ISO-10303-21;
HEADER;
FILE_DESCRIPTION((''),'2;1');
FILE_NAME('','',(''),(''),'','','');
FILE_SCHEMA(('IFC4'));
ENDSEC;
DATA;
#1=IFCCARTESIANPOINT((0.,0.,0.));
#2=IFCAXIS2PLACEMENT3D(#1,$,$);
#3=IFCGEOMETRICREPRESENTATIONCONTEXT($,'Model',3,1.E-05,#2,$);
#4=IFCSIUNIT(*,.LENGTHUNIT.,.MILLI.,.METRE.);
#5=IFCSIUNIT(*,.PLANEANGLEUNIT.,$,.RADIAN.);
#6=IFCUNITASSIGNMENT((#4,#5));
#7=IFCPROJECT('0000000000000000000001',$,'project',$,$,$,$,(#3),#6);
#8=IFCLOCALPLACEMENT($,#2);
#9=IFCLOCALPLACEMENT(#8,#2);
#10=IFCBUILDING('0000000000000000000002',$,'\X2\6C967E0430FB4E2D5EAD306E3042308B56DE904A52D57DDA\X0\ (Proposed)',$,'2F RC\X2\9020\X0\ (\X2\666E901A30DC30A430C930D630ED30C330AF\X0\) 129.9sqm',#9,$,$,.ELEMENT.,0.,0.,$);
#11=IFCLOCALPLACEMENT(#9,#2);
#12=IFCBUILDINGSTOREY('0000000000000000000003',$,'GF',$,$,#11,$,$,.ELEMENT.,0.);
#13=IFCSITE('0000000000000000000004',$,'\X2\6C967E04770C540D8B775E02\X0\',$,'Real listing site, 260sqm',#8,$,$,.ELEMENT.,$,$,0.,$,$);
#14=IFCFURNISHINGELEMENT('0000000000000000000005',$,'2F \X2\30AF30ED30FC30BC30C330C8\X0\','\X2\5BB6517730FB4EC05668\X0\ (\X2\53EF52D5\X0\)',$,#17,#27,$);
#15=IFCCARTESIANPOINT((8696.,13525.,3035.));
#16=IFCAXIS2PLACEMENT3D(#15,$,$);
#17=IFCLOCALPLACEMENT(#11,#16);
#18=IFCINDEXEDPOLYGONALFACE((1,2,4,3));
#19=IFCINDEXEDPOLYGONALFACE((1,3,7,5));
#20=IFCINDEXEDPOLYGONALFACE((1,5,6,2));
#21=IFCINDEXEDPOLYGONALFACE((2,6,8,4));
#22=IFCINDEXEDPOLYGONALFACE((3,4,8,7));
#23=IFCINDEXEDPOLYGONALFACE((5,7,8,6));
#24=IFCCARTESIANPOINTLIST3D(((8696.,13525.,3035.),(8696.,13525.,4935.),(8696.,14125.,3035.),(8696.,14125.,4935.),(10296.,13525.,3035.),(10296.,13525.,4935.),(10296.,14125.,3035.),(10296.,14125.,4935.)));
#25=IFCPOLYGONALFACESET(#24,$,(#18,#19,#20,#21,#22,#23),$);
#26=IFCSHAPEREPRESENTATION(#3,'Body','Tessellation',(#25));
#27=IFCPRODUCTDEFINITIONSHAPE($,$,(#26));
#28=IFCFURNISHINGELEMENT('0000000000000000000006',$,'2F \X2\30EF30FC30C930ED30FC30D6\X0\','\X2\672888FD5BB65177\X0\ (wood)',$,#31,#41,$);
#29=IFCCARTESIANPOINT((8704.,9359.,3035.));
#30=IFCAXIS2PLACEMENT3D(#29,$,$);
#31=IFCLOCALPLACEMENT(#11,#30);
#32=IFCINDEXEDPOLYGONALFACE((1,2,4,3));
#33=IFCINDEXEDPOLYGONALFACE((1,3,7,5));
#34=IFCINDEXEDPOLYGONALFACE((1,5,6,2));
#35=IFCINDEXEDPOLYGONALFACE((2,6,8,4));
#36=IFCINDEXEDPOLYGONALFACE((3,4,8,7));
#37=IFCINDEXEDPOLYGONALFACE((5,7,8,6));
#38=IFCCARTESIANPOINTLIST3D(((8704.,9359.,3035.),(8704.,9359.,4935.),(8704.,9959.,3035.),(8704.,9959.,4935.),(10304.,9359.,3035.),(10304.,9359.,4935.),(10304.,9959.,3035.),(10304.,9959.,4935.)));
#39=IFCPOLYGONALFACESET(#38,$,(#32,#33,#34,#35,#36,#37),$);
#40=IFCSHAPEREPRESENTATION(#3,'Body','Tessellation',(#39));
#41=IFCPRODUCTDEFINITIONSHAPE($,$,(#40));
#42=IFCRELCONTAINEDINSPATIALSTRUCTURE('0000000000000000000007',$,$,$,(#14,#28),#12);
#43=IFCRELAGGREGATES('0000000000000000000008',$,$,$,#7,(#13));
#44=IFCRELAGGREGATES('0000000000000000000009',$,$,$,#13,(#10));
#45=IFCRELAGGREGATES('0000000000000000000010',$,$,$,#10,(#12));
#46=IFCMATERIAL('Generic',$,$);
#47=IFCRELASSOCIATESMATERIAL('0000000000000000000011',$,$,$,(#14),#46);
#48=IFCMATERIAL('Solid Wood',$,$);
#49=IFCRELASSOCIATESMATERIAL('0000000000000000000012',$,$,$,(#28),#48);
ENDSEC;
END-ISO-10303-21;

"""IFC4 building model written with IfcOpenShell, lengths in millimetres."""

from ifc_helpers import new_model, si_unit, frame, frame_2d, origin, place, context, project, spatial, rectangle, extrude, material, element, save


model = new_model("IFC4")

# Units and contexts
model_context = context("Model", 3, precision=1e-05, world=origin())
ifc_project = project(units=[si_unit("LENGTHUNIT", "METRE", prefix="MILLI"), si_unit("PLANEANGLEUNIT", "RADIAN")], contexts=[model_context])

# Site, building, storey
site_placement = place(None, origin())
site = spatial("IfcSite", under=ifc_project, at=site_placement, Name="沖縄県名護市", ObjectType="Real listing site, 260sqm", CompositionType="ELEMENT", RefElevation=0.0)
building_placement = place(site_placement, origin())
building = spatial("IfcBuilding", under=site, at=building_placement, Name="沖縄・中庭のある回遊動線 (Proposed)", ObjectType="2F RC造 (普通ボイドブロック) 129.9sqm", CompositionType="ELEMENT", ElevationOfRefHeight=0.0, ElevationOfTerrain=0.0)
storey_placement = place(building_placement, origin())
storey = spatial("IfcBuildingStorey", under=building, at=storey_placement, Name="GF", CompositionType="ELEMENT", Elevation=0.0)

# Shared definitions
ifc_material_1 = material(Name="Solid Wood")

# Shared definitions
ifc_material_2 = material(Name="Generic")

# Furnishing elements
furnishing_1_placement = place(storey_placement, frame((8696.0, 13525.0, 3035.0)))
element("IfcFurnishingElement", 1, at=furnishing_1_placement, inside=storey, material=ifc_material_2, Name="2F クローゼット", Description="家具・什器 (可動)", context=model_context, shape_type="SweptSolid", body=[
    extrude(rectangle(XDim=1600.0, YDim=600.0, at=frame_2d((800.0, 300.0))), frame((8696.0, 13525.0, 3035.0)), (0.0, 0.0, 1.0), 1900.0),
])
furnishing_2_placement = place(storey_placement, frame((8704.0, 9359.0, 3035.0)))
element("IfcFurnishingElement", 2, at=furnishing_2_placement, inside=storey, material=ifc_material_1, Name="2F ワードローブ", Description="木製家具 (wood)", context=model_context, shape_type="SweptSolid", body=[
    extrude(rectangle(XDim=1600.0, YDim=600.0, at=frame_2d((800.0, 300.0))), frame((8704.0, 9359.0, 3035.0)), (0.0, 0.0, 1.0), 1900.0),
])

save(model, "model.ifc")
